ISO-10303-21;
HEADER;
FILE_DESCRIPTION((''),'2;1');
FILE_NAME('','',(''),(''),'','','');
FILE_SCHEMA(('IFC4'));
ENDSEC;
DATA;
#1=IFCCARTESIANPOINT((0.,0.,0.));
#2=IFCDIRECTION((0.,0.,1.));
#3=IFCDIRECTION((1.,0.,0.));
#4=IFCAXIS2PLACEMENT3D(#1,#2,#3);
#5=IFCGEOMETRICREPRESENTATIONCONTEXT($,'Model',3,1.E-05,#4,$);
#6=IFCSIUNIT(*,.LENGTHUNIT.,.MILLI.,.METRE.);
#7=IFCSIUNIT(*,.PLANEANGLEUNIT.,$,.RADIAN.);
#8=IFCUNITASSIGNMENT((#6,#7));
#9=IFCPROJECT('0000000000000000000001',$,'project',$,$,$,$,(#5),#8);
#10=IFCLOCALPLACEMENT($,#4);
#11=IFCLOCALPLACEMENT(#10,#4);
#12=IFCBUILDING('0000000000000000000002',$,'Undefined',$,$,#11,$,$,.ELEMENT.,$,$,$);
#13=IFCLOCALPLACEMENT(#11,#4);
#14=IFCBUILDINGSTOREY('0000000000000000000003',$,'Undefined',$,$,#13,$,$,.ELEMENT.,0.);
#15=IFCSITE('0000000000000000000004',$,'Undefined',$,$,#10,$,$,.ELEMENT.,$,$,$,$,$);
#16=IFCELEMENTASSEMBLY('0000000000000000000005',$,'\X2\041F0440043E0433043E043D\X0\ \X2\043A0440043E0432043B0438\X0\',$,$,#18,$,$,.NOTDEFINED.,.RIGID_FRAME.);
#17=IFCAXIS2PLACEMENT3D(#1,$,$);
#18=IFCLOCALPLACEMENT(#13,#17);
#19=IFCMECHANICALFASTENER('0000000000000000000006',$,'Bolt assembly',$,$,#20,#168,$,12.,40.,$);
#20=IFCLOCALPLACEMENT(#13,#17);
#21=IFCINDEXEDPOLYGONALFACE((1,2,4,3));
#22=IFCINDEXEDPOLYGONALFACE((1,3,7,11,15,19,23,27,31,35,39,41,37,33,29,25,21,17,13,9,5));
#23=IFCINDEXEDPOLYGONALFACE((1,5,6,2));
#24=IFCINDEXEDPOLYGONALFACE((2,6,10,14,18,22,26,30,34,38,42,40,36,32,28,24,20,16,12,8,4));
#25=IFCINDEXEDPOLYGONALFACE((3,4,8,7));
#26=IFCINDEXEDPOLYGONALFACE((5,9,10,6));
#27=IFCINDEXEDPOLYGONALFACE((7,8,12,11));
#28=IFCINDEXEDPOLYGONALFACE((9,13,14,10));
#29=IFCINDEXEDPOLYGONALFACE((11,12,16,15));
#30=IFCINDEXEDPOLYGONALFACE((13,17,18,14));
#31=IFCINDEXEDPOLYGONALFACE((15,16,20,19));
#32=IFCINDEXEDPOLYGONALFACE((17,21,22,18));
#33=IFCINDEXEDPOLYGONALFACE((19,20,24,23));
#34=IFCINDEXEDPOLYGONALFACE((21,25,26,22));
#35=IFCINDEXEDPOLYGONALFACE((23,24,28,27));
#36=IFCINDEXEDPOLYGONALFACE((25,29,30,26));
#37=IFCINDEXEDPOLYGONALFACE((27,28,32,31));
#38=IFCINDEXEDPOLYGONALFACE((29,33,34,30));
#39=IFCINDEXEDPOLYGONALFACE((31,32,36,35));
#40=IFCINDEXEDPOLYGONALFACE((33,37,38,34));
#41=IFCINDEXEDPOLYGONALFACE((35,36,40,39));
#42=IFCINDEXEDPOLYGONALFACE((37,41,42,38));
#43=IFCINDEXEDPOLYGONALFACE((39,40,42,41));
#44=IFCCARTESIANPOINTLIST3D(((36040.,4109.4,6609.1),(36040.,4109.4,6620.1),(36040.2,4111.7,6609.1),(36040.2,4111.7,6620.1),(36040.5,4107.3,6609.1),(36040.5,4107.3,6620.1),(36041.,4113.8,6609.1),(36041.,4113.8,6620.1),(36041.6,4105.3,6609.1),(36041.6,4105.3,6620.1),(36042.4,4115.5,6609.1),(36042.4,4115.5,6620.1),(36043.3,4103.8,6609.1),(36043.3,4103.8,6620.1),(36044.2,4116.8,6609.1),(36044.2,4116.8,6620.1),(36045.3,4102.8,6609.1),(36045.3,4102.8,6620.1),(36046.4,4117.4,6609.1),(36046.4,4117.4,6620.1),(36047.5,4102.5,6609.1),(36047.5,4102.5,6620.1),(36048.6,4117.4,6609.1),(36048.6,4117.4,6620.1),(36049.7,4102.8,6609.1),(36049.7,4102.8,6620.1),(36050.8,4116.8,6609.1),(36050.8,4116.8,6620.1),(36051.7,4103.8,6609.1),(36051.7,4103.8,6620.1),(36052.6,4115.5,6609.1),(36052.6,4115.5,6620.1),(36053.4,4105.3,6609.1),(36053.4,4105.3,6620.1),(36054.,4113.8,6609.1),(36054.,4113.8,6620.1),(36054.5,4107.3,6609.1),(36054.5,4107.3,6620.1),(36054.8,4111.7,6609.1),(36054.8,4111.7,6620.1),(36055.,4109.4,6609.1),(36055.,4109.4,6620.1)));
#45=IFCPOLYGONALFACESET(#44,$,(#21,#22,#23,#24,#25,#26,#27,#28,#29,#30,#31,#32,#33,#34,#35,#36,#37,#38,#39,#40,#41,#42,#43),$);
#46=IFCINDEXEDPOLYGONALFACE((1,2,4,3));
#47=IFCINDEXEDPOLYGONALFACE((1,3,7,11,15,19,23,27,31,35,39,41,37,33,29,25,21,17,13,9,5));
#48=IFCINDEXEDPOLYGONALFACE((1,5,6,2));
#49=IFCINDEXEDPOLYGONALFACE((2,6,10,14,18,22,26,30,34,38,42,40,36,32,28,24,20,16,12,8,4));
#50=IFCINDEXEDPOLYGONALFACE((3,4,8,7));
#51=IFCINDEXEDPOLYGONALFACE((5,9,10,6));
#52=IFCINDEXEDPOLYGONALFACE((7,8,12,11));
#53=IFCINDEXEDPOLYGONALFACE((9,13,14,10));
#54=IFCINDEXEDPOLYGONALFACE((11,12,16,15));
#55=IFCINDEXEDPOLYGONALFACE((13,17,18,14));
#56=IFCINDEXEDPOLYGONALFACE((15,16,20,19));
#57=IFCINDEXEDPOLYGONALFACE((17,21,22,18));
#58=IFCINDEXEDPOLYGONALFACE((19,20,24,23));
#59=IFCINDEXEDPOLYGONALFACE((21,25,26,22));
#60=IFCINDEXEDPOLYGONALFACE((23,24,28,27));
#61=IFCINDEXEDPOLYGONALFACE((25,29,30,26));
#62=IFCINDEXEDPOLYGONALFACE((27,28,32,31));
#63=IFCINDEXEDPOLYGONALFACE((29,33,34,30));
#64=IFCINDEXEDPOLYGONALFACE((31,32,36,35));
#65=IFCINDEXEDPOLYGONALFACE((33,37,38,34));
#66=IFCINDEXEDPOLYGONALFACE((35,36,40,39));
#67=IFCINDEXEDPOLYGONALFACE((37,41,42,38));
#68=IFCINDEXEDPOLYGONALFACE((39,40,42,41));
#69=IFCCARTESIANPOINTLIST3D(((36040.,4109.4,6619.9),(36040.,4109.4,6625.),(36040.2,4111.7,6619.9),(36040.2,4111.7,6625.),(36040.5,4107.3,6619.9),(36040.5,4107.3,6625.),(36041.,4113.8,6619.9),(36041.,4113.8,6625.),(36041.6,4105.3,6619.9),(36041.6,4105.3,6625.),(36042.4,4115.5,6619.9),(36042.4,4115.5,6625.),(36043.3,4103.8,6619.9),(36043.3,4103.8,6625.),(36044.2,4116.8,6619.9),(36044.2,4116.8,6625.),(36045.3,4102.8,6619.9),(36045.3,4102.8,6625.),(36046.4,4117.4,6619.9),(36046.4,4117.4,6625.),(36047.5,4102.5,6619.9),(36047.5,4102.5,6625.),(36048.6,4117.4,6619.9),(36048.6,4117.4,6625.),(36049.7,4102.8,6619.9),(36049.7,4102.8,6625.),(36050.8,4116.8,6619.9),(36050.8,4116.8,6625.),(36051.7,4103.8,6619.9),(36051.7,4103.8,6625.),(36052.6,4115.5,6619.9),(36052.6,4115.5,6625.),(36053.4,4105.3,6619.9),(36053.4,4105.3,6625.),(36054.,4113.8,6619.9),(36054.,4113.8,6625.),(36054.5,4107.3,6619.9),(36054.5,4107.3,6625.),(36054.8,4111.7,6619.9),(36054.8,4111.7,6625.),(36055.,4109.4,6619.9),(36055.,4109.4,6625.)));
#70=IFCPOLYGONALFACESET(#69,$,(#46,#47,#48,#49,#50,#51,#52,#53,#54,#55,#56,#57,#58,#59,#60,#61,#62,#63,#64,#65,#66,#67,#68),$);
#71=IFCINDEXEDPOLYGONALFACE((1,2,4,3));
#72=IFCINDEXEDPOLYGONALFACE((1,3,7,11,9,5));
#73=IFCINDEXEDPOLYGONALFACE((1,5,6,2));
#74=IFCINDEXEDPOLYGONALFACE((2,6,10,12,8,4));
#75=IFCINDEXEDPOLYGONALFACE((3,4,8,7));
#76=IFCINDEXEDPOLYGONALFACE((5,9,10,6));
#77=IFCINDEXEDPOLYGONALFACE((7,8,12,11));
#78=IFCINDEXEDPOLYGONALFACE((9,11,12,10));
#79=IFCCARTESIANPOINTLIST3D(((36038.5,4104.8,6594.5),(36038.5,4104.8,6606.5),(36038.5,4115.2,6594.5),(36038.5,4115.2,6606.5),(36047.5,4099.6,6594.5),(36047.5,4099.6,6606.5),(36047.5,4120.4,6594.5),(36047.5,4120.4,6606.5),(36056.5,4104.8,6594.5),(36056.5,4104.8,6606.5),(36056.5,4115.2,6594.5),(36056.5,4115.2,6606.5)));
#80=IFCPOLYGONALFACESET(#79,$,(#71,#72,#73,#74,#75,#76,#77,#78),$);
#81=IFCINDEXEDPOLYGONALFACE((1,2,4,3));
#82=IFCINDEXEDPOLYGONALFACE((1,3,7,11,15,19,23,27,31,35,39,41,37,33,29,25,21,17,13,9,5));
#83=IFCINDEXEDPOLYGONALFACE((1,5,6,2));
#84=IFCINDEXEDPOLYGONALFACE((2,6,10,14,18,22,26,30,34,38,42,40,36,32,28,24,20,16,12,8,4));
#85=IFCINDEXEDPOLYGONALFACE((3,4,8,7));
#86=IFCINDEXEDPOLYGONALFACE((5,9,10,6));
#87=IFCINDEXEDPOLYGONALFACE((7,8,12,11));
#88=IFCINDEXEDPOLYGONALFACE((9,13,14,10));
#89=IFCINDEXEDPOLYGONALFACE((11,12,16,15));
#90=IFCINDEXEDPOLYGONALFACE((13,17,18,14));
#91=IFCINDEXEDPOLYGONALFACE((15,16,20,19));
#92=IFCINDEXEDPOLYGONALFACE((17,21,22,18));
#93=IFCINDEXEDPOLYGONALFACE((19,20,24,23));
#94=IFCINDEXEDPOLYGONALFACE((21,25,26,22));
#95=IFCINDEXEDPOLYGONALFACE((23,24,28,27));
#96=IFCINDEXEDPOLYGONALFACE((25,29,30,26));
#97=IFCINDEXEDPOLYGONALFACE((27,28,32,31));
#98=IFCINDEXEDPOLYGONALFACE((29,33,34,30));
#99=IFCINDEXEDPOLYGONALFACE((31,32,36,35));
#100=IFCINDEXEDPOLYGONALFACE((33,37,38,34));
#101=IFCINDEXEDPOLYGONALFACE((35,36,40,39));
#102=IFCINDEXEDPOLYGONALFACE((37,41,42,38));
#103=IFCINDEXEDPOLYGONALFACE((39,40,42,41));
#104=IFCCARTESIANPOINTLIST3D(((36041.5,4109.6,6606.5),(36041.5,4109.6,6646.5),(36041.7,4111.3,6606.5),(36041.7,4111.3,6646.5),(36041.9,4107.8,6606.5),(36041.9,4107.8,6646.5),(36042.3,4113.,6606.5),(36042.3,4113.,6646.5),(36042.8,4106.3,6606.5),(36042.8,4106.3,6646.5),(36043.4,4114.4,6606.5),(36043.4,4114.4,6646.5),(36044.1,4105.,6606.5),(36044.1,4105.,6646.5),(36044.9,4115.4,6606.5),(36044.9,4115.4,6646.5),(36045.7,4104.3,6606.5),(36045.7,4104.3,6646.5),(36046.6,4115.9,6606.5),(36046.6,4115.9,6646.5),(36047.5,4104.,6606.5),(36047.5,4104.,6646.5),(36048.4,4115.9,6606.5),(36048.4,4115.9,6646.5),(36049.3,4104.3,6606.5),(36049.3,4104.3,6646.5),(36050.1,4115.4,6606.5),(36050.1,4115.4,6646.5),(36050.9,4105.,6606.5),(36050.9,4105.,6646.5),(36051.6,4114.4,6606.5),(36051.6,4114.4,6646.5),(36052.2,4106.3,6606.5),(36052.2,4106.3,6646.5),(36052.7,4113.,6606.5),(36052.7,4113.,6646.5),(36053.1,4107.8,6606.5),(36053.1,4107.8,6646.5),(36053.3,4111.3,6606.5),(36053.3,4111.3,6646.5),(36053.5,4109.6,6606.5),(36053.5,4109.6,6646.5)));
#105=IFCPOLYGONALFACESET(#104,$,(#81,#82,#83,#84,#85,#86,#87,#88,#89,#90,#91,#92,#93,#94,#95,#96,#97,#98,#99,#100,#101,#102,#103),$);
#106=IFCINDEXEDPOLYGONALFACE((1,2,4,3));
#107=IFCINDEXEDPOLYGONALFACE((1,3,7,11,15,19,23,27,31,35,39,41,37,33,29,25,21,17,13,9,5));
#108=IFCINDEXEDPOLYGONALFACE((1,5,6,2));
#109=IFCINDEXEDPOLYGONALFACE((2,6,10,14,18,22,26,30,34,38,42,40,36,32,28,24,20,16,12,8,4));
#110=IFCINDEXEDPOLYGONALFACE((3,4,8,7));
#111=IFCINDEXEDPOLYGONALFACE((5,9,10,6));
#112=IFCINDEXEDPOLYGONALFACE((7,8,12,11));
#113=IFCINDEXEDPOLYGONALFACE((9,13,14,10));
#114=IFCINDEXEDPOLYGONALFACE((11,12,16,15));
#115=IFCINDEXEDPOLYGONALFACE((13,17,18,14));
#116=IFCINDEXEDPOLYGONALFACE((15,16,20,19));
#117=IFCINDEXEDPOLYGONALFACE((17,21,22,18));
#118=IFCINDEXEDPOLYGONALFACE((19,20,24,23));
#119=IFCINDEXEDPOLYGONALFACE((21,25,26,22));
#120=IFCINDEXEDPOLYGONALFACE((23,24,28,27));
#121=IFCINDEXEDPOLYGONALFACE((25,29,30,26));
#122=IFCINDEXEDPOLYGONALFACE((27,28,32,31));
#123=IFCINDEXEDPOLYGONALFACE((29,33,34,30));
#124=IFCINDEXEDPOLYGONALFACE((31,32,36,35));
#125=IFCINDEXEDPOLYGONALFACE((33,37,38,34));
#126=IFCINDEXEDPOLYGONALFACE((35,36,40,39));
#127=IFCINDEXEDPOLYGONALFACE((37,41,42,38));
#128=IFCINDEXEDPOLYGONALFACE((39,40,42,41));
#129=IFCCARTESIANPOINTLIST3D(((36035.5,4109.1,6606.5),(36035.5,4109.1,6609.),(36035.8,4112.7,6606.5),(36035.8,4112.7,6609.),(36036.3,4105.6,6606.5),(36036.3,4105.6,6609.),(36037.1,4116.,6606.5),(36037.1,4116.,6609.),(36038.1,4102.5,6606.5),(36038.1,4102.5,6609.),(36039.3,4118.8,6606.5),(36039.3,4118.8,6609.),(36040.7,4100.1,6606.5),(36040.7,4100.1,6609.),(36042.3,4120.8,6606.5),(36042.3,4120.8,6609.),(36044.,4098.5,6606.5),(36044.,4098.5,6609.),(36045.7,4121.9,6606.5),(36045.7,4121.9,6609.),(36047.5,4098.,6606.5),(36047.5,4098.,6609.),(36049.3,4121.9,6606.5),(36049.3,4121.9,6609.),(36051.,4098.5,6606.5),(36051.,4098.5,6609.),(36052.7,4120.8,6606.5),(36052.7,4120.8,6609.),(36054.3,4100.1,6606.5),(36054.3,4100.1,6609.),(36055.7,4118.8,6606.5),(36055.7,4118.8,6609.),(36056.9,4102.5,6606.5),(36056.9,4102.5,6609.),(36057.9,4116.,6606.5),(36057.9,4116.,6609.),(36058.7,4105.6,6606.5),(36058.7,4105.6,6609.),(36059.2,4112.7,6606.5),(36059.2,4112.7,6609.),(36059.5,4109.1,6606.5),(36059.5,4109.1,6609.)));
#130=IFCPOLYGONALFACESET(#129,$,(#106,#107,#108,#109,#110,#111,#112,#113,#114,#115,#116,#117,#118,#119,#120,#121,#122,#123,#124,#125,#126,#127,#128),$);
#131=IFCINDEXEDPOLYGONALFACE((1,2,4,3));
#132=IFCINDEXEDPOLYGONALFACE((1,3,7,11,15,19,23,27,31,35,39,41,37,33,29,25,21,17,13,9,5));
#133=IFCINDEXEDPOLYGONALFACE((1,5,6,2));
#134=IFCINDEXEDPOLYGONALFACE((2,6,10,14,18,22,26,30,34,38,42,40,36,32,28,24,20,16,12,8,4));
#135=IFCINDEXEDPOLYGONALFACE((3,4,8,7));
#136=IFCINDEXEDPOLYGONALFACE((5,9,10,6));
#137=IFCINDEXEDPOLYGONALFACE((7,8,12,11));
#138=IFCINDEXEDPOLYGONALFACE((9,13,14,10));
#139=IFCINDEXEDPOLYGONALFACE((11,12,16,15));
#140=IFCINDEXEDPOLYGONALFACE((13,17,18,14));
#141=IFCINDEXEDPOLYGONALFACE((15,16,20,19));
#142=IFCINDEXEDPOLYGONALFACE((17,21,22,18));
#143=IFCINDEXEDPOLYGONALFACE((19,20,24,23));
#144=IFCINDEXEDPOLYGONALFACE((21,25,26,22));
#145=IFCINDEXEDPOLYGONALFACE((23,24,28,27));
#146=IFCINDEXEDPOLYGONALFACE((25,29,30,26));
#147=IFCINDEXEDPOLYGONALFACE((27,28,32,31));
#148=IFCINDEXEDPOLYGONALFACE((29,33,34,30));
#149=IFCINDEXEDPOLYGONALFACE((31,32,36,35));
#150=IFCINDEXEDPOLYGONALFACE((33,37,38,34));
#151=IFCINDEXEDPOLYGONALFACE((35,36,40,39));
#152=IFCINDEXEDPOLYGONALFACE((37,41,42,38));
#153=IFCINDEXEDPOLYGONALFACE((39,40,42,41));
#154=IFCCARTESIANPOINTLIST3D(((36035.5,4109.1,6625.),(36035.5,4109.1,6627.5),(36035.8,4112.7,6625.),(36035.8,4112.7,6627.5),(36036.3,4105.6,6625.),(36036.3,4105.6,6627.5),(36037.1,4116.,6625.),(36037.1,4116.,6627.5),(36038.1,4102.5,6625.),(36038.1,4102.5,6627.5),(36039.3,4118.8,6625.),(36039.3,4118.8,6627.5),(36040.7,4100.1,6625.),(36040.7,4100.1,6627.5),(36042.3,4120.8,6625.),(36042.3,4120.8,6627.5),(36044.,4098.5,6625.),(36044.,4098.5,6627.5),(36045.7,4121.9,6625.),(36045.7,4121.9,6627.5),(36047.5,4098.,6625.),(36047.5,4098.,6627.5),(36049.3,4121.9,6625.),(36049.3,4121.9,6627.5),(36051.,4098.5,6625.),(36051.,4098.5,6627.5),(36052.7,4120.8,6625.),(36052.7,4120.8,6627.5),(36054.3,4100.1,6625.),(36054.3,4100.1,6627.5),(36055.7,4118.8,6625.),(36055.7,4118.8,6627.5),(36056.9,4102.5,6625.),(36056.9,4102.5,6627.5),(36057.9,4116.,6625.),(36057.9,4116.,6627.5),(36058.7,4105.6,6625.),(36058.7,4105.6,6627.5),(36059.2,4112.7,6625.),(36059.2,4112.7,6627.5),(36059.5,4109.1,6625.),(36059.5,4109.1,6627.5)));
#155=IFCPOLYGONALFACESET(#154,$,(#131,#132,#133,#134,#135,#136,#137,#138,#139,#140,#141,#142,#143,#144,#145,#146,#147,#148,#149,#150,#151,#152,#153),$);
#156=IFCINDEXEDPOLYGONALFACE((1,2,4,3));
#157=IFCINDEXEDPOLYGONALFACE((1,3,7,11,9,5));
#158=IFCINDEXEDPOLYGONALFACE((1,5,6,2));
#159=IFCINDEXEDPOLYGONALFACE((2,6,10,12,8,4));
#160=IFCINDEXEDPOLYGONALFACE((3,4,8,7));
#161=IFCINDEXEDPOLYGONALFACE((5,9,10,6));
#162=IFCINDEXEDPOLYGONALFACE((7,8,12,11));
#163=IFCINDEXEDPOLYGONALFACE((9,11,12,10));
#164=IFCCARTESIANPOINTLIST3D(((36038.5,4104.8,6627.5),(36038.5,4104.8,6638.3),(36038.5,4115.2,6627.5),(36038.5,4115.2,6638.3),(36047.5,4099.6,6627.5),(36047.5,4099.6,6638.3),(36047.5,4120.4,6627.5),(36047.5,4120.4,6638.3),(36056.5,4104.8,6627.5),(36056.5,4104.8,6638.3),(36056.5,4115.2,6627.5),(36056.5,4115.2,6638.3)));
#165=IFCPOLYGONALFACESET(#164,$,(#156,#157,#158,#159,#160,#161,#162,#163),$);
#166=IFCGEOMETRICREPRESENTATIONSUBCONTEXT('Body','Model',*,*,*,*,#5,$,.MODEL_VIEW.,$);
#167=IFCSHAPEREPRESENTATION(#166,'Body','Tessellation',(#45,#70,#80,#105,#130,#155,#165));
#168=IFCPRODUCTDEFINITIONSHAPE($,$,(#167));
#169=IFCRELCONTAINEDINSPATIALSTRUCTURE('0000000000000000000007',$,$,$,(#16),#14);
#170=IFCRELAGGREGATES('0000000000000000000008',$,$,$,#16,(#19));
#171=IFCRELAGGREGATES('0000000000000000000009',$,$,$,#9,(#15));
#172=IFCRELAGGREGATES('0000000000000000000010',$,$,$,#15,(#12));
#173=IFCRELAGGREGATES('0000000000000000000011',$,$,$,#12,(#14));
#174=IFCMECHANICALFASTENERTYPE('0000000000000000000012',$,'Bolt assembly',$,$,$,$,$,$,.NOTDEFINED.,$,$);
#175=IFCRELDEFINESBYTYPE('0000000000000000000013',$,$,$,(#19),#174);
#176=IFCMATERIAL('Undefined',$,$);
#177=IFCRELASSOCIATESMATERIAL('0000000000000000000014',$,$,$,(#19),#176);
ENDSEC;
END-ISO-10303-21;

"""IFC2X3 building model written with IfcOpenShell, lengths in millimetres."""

from ifc_helpers import new_model, si_unit, frame, origin_with_axes, origin_2d_with_axis, place, context, subcontext, project, spatial, polyline, circle, outline, extrude, source, transform, mapped, material, type_object, element, aggregate, save


model = new_model("IFC2X3")

# Units and contexts
model_context = context("Model", 3, precision=1e-05, world=origin_with_axes())
body_context = subcontext(model_context, "Body", "Model", "MODEL_VIEW")
ifc_project = project(units=[si_unit("LENGTHUNIT", "METRE", prefix="MILLI"), si_unit("PLANEANGLEUNIT", "RADIAN")], contexts=[model_context])

# Site, building, storey
site_placement = place(None, origin_with_axes())
site = spatial("IfcSite", under=ifc_project, at=site_placement, Name="Undefined", CompositionType="ELEMENT")
building_placement = place(site_placement, origin_with_axes())
building = spatial("IfcBuilding", under=site, at=building_placement, Name="Undefined", CompositionType="ELEMENT")
storey_placement = place(building_placement, origin_with_axes())
storey = spatial("IfcBuildingStorey", under=building, at=storey_placement, Name="Undefined", CompositionType="ELEMENT", Elevation=0.0)

# Element assembly
assembly_1_placement = place(storey_placement, origin_with_axes())
assembly_1 = element("IfcElementAssembly", 1, at=assembly_1_placement, inside=storey, Name="Прогон кровли", AssemblyPlace="NOTDEFINED", PredefinedType="RIGID_FRAME")

# Mechanical fastener
ifc_material_1 = material(Name="Undefined")
mechanical_fastener_type = type_object("IfcMechanicalFastenerType", Name="Bolt assembly")
shared_shape_1 = source(origin_with_axes(), body_context, "Body", "SweptSolid", [
    extrude(circle(Radius=7.5, at=origin_2d_with_axis()), frame((0.0, -10.9, 0.0), z_axis=(0.0, 1.0, 0.0), x_axis=(1.0, 0.0, 0.0)), (0.0, 0.0, 1.0), 11.0),
    extrude(circle(Radius=7.5, at=origin_2d_with_axis()), frame((0.0, -0.1, 0.0), z_axis=(0.0, 1.0, 0.0), x_axis=(1.0, 0.0, 0.0)), (0.0, 0.0, 1.0), 5.1),
    extrude(outline(polyline([(10.4, 0.0), (5.2, 9.0), (-5.2, 9.0), (-10.4, 0.0), (-5.2, -9.0), (5.2, -9.0), (10.4, 0.0)])), frame((0.0, -25.5, 0.0), z_axis=(0.0, 1.0, 0.0), x_axis=(1.0, 0.0, 0.0)), (0.0, 0.0, 1.0), 12.0),
    extrude(circle(Radius=6.0, at=origin_2d_with_axis()), frame((0.0, -13.5, 0.0), z_axis=(0.0, 1.0, 0.0), x_axis=(1.0, 0.0, 0.0)), (0.0, 0.0, 1.0), 40.0),
    extrude(circle(Radius=12.0, at=origin_2d_with_axis()), frame((0.0, -13.5, 0.0), z_axis=(0.0, 1.0, 0.0), x_axis=(1.0, 0.0, 0.0)), (0.0, 0.0, 1.0), 2.5),
    extrude(circle(Radius=12.0, at=origin_2d_with_axis()), frame((0.0, 5.0, 0.0), z_axis=(0.0, 1.0, 0.0), x_axis=(1.0, 0.0, 0.0)), (0.0, 0.0, 1.0), 2.5),
    extrude(outline(polyline([(10.4, 0.0), (5.2, 9.0), (-5.2, 9.0), (-10.4, 0.0), (-5.2, -9.0), (5.2, -9.0), (10.4, 0.0)])), frame((0.0, 7.5, 0.0), z_axis=(0.0, 1.0, 0.0), x_axis=(1.0, 0.0, 0.0)), (0.0, 0.0, 1.0), 10.8),
])
mechanical_fastener_1_placement = place(assembly_1_placement, frame((36047.5, 4110.0, 6620.0), z_axis=(-1.0, 0.0, 0.0), x_axis=(0.0, -1.0, 0.0)))
mechanical_fastener_1 = element("IfcMechanicalFastener", 2, at=mechanical_fastener_1_placement, type_object=mechanical_fastener_type, material=ifc_material_1, Name="Bolt assembly", NominalDiameter=12.0, NominalLength=40.0, context=body_context, shape_type="MappedRepresentation", body=[
    mapped(shared_shape_1, transform((0.0, 0.0, 0.0))),
])
aggregate(assembly_1, [mechanical_fastener_1])

save(model, "model.ifc")
